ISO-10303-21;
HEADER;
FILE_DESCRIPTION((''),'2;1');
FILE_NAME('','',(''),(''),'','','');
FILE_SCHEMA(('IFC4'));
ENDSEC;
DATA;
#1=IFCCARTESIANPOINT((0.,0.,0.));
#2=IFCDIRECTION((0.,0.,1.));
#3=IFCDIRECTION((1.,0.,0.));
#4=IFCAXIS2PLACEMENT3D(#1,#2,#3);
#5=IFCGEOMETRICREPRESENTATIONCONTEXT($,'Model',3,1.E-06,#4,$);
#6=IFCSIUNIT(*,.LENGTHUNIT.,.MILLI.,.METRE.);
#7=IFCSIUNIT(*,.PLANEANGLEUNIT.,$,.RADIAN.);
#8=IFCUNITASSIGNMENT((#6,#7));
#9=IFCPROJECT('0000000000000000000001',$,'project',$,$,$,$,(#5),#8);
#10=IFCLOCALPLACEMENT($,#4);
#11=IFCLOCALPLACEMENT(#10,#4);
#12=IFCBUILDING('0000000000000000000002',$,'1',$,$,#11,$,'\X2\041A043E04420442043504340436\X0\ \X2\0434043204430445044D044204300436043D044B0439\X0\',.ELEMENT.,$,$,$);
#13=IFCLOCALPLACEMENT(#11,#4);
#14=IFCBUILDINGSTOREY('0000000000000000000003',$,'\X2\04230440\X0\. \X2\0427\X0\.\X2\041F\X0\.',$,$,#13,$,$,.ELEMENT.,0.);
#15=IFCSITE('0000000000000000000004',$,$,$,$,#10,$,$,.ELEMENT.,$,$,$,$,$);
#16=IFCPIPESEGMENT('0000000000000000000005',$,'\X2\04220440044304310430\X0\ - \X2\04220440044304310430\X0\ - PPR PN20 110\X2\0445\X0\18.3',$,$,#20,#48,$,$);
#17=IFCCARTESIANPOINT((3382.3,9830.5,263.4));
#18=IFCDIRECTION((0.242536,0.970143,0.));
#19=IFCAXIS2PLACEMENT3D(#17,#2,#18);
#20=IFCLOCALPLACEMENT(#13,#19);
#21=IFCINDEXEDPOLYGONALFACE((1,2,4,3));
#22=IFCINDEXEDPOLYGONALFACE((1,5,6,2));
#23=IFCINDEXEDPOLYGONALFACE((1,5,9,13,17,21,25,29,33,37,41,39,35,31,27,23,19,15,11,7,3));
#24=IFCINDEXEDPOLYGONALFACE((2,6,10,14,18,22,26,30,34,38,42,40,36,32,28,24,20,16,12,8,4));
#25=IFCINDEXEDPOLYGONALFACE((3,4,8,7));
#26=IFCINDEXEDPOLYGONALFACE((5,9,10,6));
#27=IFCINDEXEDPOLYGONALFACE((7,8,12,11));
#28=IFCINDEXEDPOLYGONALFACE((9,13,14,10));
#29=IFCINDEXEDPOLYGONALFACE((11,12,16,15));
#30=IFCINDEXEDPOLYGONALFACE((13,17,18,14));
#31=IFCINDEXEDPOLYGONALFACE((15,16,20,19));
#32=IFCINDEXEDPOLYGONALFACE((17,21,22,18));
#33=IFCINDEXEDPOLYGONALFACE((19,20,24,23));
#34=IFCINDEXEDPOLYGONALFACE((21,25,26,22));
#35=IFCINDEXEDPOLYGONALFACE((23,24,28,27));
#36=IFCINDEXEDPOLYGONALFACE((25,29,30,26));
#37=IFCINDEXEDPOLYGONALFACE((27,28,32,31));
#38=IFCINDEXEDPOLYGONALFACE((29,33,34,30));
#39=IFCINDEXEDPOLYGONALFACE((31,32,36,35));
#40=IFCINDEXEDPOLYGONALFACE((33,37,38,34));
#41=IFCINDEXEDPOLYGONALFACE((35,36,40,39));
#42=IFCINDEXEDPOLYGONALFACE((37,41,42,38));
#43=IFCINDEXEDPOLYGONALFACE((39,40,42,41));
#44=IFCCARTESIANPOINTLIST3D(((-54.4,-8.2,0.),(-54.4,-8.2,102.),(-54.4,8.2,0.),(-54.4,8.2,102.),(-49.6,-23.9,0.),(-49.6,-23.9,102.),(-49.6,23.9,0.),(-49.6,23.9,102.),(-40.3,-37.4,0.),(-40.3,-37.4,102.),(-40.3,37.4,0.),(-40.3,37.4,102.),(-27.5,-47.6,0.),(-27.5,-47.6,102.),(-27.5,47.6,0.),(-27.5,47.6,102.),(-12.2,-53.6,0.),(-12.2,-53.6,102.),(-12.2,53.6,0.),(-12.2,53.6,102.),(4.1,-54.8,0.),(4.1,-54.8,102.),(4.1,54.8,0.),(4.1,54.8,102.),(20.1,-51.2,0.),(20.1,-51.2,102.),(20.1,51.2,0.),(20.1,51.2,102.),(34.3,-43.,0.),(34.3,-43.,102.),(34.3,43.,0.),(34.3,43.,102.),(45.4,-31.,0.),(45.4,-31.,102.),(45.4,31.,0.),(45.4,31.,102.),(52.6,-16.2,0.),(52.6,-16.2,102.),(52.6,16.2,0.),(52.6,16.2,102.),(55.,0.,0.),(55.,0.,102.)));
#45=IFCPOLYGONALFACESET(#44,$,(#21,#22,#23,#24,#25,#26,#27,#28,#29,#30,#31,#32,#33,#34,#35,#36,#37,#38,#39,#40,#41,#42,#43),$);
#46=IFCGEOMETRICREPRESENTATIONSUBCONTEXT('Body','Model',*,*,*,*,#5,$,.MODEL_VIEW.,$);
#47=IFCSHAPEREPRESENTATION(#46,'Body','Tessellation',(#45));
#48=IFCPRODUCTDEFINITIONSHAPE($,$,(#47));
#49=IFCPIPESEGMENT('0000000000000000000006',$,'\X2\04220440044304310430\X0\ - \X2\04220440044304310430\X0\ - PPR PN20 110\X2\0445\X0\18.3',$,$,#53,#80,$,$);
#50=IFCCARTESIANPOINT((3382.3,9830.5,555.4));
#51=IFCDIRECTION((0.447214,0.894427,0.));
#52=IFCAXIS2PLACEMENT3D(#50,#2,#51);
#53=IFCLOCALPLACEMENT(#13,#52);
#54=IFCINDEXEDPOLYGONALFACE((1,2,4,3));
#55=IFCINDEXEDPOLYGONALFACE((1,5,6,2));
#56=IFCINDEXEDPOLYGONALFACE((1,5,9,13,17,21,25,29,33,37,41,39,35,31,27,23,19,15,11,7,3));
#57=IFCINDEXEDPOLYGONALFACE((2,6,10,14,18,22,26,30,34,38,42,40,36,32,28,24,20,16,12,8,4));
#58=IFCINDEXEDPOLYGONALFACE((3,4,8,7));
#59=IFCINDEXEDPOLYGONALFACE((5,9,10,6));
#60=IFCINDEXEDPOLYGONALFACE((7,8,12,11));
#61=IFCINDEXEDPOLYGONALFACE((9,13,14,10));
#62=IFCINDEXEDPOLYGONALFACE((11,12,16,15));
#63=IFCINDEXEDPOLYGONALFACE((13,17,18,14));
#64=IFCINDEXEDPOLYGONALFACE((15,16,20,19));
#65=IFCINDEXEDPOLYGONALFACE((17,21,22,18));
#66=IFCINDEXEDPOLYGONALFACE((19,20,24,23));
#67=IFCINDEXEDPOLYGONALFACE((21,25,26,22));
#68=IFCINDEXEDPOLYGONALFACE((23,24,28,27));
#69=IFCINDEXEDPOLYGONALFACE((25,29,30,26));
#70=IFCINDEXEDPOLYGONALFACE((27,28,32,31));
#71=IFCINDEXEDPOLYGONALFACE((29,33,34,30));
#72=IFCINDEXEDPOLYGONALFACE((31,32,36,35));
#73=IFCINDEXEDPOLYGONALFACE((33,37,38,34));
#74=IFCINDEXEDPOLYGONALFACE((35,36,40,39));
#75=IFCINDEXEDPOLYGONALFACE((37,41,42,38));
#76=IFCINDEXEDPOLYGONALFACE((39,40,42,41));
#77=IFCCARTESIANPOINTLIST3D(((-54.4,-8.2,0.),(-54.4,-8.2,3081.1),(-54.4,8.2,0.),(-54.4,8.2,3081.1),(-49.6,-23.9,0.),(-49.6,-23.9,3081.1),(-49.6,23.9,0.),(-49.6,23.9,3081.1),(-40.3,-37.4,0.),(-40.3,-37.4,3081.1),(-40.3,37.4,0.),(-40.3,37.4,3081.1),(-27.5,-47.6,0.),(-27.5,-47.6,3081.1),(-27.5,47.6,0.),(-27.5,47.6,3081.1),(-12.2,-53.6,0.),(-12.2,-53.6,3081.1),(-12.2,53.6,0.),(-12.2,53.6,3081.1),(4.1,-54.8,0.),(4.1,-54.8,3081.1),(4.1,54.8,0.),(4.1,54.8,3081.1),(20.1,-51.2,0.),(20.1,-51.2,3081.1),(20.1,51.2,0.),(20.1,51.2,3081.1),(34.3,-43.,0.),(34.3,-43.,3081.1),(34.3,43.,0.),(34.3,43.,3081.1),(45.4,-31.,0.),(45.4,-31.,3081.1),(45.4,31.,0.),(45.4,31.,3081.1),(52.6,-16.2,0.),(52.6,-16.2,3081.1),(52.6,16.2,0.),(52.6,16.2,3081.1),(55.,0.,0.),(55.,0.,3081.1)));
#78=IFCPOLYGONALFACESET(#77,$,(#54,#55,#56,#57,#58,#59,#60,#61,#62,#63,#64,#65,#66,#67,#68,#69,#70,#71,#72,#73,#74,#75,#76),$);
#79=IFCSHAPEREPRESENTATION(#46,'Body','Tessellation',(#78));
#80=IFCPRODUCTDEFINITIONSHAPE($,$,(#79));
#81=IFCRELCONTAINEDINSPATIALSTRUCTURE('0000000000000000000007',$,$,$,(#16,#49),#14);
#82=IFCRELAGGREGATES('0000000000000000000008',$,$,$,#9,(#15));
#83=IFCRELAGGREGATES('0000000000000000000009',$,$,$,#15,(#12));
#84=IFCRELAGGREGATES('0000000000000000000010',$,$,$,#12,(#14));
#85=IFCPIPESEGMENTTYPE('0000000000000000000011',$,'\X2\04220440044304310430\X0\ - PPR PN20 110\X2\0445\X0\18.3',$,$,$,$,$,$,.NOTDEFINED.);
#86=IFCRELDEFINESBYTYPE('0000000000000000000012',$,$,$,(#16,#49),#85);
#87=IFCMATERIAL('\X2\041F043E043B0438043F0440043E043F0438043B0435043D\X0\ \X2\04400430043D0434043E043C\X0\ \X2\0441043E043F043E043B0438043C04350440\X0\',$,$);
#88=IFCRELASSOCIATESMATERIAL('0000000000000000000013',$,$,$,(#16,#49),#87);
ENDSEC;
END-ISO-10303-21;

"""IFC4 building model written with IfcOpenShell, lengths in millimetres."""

from ifc_helpers import new_model, entity, si_unit, frame, origin_with_axes, place, context, subcontext, project, spatial, source, transform, mapped, material, type_object, element, save


model = new_model("IFC4")

# Units and contexts
model_context = context("Model", 3, precision=1e-06, world=origin_with_axes())
body_context = subcontext(model_context, "Body", "Model", "MODEL_VIEW")
ifc_project = project(units=[si_unit("LENGTHUNIT", "METRE", prefix="MILLI"), si_unit("PLANEANGLEUNIT", "RADIAN")], contexts=[model_context])

# Site, building, storey
site_placement = place(None, origin_with_axes())
site = spatial("IfcSite", under=ifc_project, at=site_placement, CompositionType="ELEMENT")
building_placement = place(site_placement, origin_with_axes())
building = spatial("IfcBuilding", under=site, at=building_placement, Name="1", LongName="Коттедж двухэтажный", CompositionType="ELEMENT")
storey_placement = place(building_placement, origin_with_axes())
storey = spatial("IfcBuildingStorey", under=building, at=storey_placement, Name="Ур. Ч.П.", CompositionType="ELEMENT", Elevation=0.0)

# Pipe segments
ifc_material_1 = material(Name="Полипропилен рандом сополимер")
pipe_segment_type_1 = type_object("IfcPipeSegmentType", Name="Труба - PPR PN20 110х18.3", PredefinedType="NOTDEFINED")
shared_shape_1 = source(origin_with_axes(), body_context, "Body", "AdvancedSweptSolid", [
    entity("IfcSweptDiskSolid", entity("IfcIndexedPolyCurve", entity("IfcCartesianPointList3D", [[0.0, 0.0, 0.0], [0.0, 0.0, 102.0]]), [entity("IfcLineIndex", [1, 2])]), 55.0),
])
pipe_segment_1_placement = place(storey_placement, frame((3382.3, 9830.5, 263.4), z_axis=(0.0, 0.0, 1.0), x_axis=(0.242536, 0.970143, 0.0)))
element("IfcPipeSegment", 1, at=pipe_segment_1_placement, inside=storey, type_object=pipe_segment_type_1, material=ifc_material_1, Name="Труба - Труба - PPR PN20 110х18.3", context=body_context, shape_type="MappedRepresentation", body=[
    mapped(shared_shape_1, transform((0.0, 0.0, 0.0), x_axis=(1.0, 0.0, 0.0), y_axis=(0.0, 1.0, 0.0), z_axis=(0.0, 0.0, 1.0), scale=1.0)),
])
shared_shape_2 = source(origin_with_axes(), body_context, "Body", "AdvancedSweptSolid", [
    entity("IfcSweptDiskSolid", entity("IfcIndexedPolyCurve", entity("IfcCartesianPointList3D", [[0.0, 0.0, 0.0], [0.0, 0.0, 3081.1]]), [entity("IfcLineIndex", [1, 2])]), 55.0),
])
pipe_segment_2_placement = place(storey_placement, frame((3382.3, 9830.5, 555.4), z_axis=(0.0, 0.0, 1.0), x_axis=(0.447214, 0.894427, 0.0)))
element("IfcPipeSegment", 2, at=pipe_segment_2_placement, inside=storey, type_object=pipe_segment_type_1, material=ifc_material_1, Name="Труба - Труба - PPR PN20 110х18.3", context=body_context, shape_type="MappedRepresentation", body=[
    mapped(shared_shape_2, transform((0.0, 0.0, 0.0), x_axis=(1.0, 0.0, 0.0), y_axis=(0.0, 1.0, 0.0), z_axis=(0.0, 0.0, 1.0), scale=1.0)),
])

save(model, "model.ifc")
